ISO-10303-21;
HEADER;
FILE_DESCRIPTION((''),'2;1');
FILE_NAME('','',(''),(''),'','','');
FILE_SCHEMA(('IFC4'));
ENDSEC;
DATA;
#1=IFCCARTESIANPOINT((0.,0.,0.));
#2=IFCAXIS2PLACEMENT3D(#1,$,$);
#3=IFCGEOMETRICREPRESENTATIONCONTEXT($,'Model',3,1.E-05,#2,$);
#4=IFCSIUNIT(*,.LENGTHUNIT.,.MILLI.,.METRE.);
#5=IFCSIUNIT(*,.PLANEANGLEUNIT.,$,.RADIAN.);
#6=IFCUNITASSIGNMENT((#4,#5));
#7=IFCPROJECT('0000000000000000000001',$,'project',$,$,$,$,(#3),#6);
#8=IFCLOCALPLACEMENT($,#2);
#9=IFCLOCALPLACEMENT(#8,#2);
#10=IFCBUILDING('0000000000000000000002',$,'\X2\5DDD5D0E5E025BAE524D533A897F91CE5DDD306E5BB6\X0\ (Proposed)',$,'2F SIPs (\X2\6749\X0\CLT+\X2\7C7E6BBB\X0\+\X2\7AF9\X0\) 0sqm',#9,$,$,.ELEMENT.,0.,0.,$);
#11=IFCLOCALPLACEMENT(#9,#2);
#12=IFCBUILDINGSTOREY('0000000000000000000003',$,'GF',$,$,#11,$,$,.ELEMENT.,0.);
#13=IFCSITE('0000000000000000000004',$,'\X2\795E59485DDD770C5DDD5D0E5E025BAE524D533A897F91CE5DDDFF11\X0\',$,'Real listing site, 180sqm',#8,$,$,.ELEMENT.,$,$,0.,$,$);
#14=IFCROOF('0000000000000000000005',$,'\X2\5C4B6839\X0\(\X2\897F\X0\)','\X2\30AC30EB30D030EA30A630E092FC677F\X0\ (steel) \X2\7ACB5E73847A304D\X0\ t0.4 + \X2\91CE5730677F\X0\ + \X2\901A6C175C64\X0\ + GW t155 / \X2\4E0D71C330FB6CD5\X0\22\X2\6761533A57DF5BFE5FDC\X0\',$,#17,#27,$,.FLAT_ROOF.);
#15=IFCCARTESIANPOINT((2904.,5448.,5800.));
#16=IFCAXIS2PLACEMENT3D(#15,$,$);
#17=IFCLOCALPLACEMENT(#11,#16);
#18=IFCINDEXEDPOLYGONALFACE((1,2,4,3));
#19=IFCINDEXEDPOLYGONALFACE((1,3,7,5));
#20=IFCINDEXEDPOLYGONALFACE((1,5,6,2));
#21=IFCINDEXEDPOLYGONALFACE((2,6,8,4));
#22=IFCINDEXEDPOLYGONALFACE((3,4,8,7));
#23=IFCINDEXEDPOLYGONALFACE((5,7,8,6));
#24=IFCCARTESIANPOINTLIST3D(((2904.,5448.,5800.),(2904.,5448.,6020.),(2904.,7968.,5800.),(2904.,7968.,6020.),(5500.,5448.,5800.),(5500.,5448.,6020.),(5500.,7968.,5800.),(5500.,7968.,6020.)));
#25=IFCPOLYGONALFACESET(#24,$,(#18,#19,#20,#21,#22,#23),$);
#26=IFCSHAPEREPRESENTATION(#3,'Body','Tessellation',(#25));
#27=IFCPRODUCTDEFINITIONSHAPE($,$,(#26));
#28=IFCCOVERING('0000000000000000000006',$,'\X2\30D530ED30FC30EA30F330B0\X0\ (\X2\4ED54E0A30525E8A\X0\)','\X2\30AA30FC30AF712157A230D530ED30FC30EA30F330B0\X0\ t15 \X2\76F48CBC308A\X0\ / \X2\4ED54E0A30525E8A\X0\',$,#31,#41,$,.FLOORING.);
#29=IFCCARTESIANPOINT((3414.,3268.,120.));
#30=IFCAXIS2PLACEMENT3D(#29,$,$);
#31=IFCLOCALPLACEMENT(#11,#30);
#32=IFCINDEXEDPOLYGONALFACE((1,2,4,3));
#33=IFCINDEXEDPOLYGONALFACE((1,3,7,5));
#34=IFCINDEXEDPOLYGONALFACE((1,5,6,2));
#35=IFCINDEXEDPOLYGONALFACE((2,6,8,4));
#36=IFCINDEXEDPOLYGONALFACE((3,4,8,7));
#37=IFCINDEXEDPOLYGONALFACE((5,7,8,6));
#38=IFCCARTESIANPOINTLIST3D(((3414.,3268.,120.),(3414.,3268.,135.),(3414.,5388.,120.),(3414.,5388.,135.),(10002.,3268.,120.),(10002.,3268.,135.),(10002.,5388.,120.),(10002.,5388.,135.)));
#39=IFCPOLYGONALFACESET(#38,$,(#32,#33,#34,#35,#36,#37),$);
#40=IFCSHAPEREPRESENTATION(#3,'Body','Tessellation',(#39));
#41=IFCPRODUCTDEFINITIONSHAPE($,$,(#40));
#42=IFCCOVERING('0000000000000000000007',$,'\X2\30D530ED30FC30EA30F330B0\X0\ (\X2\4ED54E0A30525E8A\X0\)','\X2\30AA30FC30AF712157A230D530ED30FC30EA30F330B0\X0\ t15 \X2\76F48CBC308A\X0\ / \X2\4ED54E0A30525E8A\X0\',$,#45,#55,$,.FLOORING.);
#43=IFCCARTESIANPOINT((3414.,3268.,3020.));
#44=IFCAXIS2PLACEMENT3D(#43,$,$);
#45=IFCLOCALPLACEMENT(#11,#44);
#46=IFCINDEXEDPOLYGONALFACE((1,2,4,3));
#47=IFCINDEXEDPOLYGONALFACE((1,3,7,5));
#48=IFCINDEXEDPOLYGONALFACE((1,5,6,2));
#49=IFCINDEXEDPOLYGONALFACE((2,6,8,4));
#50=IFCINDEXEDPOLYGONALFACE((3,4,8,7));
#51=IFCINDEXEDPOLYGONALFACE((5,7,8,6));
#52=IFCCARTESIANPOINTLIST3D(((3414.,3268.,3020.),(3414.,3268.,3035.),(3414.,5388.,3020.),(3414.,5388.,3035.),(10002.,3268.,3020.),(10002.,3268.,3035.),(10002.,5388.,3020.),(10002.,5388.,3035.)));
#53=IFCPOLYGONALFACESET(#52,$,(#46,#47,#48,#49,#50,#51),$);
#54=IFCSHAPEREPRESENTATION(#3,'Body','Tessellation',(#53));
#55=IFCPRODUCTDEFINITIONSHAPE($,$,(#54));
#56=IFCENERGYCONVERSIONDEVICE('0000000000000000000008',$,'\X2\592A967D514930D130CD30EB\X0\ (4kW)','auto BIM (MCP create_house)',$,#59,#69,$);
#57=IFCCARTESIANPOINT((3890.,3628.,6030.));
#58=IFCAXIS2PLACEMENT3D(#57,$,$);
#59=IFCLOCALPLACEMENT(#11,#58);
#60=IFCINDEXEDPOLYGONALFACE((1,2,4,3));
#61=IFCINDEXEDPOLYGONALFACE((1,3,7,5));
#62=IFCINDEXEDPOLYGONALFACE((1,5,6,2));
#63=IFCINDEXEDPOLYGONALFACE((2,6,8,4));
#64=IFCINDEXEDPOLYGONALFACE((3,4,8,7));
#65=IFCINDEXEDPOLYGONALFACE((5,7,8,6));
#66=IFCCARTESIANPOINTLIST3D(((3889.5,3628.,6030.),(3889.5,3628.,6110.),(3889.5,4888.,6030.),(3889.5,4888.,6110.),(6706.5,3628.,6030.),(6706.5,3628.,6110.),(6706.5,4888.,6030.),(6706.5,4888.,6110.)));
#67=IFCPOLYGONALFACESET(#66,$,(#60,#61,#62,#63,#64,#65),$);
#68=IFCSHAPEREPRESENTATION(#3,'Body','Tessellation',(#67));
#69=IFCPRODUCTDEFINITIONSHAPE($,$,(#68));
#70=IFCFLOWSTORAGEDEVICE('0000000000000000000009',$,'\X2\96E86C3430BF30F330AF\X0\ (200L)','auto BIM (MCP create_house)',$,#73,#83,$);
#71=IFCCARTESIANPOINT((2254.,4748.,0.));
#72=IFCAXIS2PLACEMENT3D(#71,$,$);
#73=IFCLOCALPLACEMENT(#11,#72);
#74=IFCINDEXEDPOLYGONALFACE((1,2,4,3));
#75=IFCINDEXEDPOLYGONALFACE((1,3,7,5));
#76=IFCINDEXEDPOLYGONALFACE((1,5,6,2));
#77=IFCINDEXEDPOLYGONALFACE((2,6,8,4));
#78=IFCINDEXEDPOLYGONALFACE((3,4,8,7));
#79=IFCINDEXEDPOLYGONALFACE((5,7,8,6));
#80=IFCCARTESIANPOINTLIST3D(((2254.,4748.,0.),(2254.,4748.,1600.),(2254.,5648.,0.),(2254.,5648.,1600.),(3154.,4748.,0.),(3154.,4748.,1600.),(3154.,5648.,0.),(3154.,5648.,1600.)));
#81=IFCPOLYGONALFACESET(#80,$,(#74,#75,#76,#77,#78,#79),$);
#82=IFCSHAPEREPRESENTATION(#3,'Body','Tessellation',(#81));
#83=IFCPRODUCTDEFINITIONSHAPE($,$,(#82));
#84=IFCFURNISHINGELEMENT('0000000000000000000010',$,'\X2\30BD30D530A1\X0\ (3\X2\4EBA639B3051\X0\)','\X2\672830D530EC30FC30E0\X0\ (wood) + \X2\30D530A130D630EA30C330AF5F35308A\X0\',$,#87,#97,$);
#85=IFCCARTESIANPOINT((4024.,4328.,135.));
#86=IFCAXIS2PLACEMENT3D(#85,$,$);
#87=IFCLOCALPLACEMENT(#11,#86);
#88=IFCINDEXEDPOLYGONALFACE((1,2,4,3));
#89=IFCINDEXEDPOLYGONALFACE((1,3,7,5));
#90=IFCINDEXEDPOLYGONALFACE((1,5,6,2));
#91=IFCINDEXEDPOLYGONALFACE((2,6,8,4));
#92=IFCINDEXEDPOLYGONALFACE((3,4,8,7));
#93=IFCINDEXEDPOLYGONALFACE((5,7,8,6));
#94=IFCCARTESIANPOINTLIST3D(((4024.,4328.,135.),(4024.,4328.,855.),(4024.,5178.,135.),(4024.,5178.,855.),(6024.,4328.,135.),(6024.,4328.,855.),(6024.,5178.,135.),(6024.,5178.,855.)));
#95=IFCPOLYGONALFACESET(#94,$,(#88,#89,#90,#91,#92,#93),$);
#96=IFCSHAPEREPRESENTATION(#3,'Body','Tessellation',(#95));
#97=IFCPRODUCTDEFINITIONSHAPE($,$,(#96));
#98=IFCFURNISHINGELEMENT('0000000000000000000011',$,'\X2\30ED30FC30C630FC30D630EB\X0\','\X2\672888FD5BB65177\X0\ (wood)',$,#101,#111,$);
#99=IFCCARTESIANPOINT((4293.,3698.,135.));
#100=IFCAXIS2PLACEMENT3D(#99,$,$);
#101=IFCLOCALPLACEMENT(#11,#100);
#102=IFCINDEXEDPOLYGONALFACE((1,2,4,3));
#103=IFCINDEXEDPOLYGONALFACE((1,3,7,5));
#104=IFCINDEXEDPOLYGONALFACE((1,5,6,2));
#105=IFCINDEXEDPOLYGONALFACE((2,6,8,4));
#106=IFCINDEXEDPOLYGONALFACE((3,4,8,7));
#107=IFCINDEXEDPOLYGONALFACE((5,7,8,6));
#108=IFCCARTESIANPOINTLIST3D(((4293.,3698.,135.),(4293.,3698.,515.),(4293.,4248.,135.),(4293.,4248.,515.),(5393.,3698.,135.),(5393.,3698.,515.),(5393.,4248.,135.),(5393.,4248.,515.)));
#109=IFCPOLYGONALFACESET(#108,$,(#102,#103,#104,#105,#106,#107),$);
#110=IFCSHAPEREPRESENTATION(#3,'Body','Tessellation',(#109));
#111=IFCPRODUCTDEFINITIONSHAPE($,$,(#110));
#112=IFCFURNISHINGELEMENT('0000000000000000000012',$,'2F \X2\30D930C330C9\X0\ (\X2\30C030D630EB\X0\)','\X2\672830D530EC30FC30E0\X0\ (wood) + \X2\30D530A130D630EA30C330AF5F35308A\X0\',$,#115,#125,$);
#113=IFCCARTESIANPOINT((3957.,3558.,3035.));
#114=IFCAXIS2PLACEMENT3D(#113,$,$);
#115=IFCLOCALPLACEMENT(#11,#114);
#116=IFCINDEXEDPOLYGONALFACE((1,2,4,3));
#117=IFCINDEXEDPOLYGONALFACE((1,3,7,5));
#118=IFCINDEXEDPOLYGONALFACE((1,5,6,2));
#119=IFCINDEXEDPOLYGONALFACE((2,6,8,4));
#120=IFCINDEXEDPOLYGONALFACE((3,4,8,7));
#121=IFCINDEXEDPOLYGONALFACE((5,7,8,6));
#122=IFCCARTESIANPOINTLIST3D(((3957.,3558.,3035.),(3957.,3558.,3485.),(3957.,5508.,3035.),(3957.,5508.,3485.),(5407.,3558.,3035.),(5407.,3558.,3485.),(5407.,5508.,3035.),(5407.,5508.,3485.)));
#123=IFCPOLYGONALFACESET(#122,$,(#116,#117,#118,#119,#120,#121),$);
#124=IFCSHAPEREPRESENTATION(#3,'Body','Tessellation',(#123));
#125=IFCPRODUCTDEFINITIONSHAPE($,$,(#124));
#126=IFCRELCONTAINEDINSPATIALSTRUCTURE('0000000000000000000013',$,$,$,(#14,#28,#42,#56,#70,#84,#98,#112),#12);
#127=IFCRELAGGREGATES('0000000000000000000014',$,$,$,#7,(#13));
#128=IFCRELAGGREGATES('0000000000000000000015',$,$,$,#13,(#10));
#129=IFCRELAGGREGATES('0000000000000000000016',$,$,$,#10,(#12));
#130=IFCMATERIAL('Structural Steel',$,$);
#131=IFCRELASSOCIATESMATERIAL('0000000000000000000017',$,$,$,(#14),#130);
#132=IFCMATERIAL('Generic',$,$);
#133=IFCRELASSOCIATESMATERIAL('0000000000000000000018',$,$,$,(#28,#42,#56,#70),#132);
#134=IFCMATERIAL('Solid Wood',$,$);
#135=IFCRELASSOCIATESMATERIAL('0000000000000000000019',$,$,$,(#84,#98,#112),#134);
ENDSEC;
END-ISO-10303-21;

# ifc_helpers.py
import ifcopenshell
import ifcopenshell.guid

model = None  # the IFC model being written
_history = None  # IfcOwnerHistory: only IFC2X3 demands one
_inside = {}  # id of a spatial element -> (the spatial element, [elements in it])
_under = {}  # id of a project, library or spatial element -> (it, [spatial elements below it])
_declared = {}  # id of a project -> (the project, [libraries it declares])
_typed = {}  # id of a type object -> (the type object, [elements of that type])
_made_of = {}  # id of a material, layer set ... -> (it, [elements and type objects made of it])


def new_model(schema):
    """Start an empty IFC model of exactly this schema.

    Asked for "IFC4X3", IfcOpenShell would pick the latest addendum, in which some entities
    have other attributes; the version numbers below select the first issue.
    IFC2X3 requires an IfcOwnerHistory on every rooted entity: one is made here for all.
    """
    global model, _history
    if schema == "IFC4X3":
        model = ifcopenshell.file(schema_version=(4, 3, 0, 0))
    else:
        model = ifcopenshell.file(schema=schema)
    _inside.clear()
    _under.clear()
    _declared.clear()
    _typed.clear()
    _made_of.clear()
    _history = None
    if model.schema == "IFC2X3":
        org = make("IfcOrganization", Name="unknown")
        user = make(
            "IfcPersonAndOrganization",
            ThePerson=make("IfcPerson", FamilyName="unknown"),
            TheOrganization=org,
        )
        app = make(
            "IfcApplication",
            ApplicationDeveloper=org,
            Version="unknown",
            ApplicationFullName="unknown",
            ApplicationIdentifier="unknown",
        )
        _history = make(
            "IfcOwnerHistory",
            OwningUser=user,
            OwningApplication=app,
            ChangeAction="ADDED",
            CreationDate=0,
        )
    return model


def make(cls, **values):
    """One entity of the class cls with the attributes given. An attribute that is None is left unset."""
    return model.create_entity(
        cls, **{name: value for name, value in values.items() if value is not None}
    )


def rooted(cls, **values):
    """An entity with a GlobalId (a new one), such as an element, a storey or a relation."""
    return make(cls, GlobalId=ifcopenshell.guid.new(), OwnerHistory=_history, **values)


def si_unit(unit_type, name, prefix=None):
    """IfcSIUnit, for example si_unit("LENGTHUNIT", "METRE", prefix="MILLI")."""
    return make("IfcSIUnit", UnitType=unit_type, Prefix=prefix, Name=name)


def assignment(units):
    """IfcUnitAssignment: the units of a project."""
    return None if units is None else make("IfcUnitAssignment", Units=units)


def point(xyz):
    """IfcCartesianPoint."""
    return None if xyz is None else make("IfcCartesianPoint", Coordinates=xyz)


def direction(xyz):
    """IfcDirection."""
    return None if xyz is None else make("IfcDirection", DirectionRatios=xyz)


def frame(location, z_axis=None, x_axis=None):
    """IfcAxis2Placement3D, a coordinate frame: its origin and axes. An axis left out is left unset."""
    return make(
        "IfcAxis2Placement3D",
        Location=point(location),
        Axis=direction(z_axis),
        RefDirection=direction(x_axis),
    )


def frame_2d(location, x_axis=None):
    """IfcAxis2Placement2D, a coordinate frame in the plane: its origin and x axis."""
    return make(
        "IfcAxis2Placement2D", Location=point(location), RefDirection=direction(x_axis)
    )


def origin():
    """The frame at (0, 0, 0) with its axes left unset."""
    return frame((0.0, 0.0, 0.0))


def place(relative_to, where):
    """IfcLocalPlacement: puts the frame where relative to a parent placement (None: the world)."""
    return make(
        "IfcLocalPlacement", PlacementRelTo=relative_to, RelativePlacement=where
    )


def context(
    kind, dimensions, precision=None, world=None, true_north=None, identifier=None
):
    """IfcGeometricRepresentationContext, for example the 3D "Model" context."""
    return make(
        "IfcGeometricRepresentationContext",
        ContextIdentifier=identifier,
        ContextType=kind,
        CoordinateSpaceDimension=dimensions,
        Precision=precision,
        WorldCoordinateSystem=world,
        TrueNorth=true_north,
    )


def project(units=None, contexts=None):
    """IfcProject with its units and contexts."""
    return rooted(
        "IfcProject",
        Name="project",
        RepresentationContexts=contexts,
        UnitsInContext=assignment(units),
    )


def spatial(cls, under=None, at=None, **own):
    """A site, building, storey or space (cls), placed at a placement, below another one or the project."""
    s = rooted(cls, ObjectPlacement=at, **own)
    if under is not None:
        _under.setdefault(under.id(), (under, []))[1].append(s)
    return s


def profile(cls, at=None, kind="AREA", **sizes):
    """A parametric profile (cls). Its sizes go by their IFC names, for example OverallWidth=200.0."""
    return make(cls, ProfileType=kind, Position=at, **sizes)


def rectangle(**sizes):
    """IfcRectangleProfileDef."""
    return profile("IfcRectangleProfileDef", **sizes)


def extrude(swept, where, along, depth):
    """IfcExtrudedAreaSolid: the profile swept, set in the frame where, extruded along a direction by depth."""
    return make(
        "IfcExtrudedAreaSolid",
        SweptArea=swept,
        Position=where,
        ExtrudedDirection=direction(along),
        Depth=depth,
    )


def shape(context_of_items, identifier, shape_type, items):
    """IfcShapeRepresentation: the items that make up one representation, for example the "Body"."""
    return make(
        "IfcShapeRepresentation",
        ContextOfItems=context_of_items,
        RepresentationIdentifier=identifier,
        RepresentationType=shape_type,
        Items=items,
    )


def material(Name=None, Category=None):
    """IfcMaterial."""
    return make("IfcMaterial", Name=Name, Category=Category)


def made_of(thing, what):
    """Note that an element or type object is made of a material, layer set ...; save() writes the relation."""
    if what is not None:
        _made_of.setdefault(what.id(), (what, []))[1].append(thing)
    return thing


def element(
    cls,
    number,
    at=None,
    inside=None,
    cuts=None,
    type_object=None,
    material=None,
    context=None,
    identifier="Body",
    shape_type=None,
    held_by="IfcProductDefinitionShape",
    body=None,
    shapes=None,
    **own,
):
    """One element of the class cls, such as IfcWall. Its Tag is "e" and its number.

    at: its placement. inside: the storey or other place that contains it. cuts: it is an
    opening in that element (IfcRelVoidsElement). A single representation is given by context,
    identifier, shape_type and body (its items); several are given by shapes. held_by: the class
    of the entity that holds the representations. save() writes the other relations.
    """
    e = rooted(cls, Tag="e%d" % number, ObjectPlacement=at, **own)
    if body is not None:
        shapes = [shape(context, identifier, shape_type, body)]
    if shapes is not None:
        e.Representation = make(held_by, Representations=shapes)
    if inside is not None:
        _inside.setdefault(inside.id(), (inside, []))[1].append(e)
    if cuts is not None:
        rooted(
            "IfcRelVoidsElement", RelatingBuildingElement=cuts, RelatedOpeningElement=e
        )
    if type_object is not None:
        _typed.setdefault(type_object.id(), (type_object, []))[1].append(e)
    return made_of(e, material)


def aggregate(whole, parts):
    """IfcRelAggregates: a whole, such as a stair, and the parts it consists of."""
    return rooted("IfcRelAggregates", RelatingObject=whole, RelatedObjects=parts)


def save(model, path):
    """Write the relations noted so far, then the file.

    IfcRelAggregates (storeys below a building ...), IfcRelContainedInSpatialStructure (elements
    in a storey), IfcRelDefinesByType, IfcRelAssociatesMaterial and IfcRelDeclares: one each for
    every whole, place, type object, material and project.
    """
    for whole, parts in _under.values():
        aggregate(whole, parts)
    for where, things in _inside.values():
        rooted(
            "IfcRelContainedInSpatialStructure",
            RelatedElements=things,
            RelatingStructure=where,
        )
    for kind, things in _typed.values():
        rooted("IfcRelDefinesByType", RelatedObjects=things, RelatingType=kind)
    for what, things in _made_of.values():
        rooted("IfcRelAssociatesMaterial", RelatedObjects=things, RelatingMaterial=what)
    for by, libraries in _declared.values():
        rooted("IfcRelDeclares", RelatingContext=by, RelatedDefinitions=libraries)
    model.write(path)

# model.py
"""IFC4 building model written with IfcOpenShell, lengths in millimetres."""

from ifc_helpers import new_model, si_unit, frame, frame_2d, origin, place, context, project, spatial, rectangle, extrude, material, element, save


model = new_model("IFC4")

# Units and contexts
model_context = context("Model", 3, precision=1e-05, world=origin())
ifc_project = project(units=[si_unit("LENGTHUNIT", "METRE", prefix="MILLI"), si_unit("PLANEANGLEUNIT", "RADIAN")], contexts=[model_context])

# Site, building, storey
site_placement = place(None, origin())
site = spatial("IfcSite", under=ifc_project, at=site_placement, Name="神奈川県川崎市宮前区西野川１", ObjectType="Real listing site, 180sqm", CompositionType="ELEMENT", RefElevation=0.0)
building_placement = place(site_placement, origin())
building = spatial("IfcBuilding", under=site, at=building_placement, Name="川崎市宮前区西野川の家 (Proposed)", ObjectType="2F SIPs (杉CLT+籾殻+竹) 0sqm", CompositionType="ELEMENT", ElevationOfRefHeight=0.0, ElevationOfTerrain=0.0)
storey_placement = place(building_placement, origin())
storey = spatial("IfcBuildingStorey", under=building, at=storey_placement, Name="GF", CompositionType="ELEMENT", Elevation=0.0)

# Shared definitions
ifc_material_1 = material(Name="Solid Wood")

# Roof
ifc_material_2 = material(Name="Structural Steel")
roof_1_placement = place(storey_placement, frame((2904.0, 5448.0, 5800.0)))
element("IfcRoof", 1, at=roof_1_placement, inside=storey, material=ifc_material_2, Name="屋根(西)", Description="ガルバリウム鋼板 (steel) 立平葺き t0.4 + 野地板 + 通気層 + GW t155 / 不燃・法22条区域対応", PredefinedType="FLAT_ROOF", context=model_context, shape_type="SweptSolid", body=[
    extrude(rectangle(XDim=2596.0, YDim=2520.0, at=frame_2d((1298.0, 1260.0))), frame((2904.0, 5448.0, 5800.0)), (0.0, 0.0, 1.0), 220.0),
])

# Coverings
ifc_material_3 = material(Name="Generic")
covering_1_placement = place(storey_placement, frame((3414.0, 3268.0, 120.0)))
element("IfcCovering", 2, at=covering_1_placement, inside=storey, material=ifc_material_3, Name="フローリング (仕上げ床)", Description="オーク無垢フローリング t15 直貼り / 仕上げ床", PredefinedType="FLOORING", context=model_context, shape_type="SweptSolid", body=[
    extrude(rectangle(XDim=6588.0, YDim=2120.0, at=frame_2d((3294.0, 1060.0))), frame((3414.0, 3268.0, 120.0)), (0.0, 0.0, 1.0), 15.0),
])
covering_2_placement = place(storey_placement, frame((3414.0, 3268.0, 3020.0)))
element("IfcCovering", 3, at=covering_2_placement, inside=storey, material=ifc_material_3, Name="フローリング (仕上げ床)", Description="オーク無垢フローリング t15 直貼り / 仕上げ床", PredefinedType="FLOORING", context=model_context, shape_type="SweptSolid", body=[
    extrude(rectangle(XDim=6588.0, YDim=2120.0, at=frame_2d((3294.0, 1060.0))), frame((3414.0, 3268.0, 3020.0)), (0.0, 0.0, 1.0), 15.0),
])

# Energy conversion device
energy_conversion_device_placement = place(storey_placement, frame((3890.0, 3628.0, 6030.0)))
element("IfcEnergyConversionDevice", 4, at=energy_conversion_device_placement, inside=storey, material=ifc_material_3, Name="太陽光パネル (4kW)", Description="auto BIM (MCP create_house)", context=model_context, shape_type="SweptSolid", body=[
    extrude(rectangle(XDim=2817.0, YDim=1260.0, at=frame_2d((1408.0, 630.0))), frame((3890.0, 3628.0, 6030.0)), (0.0, 0.0, 1.0), 80.0),
])

# Flow storage device
flow_storage_device_placement = place(storey_placement, frame((2254.0, 4748.0, 0.0)))
element("IfcFlowStorageDevice", 5, at=flow_storage_device_placement, inside=storey, material=ifc_material_3, Name="雨水タンク (200L)", Description="auto BIM (MCP create_house)", context=model_context, shape_type="SweptSolid", body=[
    extrude(rectangle(XDim=900.0, YDim=900.0, at=frame_2d((450.0, 450.0))), frame((2254.0, 4748.0, 0.0)), (0.0, 0.0, 1.0), 1600.0),
])

# Furnishing elements
furnishing_1_placement = place(storey_placement, frame((4024.0, 4328.0, 135.0)))
element("IfcFurnishingElement", 6, at=furnishing_1_placement, inside=storey, material=ifc_material_1, Name="ソファ (3人掛け)", Description="木フレーム (wood) + ファブリック張り", context=model_context, shape_type="SweptSolid", body=[
    extrude(rectangle(XDim=2000.0, YDim=850.0, at=frame_2d((1000.0, 425.0))), frame((4024.0, 4328.0, 135.0)), (0.0, 0.0, 1.0), 720.0),
])
furnishing_2_placement = place(storey_placement, frame((4293.0, 3698.0, 135.0)))
element("IfcFurnishingElement", 7, at=furnishing_2_placement, inside=storey, material=ifc_material_1, Name="ローテーブル", Description="木製家具 (wood)", context=model_context, shape_type="SweptSolid", body=[
    extrude(rectangle(XDim=1100.0, YDim=550.0, at=frame_2d((550.0, 275.0))), frame((4293.0, 3698.0, 135.0)), (0.0, 0.0, 1.0), 380.0),
])
furnishing_3_placement = place(storey_placement, frame((3957.0, 3558.0, 3035.0)))
element("IfcFurnishingElement", 8, at=furnishing_3_placement, inside=storey, material=ifc_material_1, Name="2F ベッド (ダブル)", Description="木フレーム (wood) + ファブリック張り", context=model_context, shape_type="SweptSolid", body=[
    extrude(rectangle(XDim=1450.0, YDim=1950.0, at=frame_2d((725.0, 975.0))), frame((3957.0, 3558.0, 3035.0)), (0.0, 0.0, 1.0), 450.0),
])

save(model, "model.ifc")
